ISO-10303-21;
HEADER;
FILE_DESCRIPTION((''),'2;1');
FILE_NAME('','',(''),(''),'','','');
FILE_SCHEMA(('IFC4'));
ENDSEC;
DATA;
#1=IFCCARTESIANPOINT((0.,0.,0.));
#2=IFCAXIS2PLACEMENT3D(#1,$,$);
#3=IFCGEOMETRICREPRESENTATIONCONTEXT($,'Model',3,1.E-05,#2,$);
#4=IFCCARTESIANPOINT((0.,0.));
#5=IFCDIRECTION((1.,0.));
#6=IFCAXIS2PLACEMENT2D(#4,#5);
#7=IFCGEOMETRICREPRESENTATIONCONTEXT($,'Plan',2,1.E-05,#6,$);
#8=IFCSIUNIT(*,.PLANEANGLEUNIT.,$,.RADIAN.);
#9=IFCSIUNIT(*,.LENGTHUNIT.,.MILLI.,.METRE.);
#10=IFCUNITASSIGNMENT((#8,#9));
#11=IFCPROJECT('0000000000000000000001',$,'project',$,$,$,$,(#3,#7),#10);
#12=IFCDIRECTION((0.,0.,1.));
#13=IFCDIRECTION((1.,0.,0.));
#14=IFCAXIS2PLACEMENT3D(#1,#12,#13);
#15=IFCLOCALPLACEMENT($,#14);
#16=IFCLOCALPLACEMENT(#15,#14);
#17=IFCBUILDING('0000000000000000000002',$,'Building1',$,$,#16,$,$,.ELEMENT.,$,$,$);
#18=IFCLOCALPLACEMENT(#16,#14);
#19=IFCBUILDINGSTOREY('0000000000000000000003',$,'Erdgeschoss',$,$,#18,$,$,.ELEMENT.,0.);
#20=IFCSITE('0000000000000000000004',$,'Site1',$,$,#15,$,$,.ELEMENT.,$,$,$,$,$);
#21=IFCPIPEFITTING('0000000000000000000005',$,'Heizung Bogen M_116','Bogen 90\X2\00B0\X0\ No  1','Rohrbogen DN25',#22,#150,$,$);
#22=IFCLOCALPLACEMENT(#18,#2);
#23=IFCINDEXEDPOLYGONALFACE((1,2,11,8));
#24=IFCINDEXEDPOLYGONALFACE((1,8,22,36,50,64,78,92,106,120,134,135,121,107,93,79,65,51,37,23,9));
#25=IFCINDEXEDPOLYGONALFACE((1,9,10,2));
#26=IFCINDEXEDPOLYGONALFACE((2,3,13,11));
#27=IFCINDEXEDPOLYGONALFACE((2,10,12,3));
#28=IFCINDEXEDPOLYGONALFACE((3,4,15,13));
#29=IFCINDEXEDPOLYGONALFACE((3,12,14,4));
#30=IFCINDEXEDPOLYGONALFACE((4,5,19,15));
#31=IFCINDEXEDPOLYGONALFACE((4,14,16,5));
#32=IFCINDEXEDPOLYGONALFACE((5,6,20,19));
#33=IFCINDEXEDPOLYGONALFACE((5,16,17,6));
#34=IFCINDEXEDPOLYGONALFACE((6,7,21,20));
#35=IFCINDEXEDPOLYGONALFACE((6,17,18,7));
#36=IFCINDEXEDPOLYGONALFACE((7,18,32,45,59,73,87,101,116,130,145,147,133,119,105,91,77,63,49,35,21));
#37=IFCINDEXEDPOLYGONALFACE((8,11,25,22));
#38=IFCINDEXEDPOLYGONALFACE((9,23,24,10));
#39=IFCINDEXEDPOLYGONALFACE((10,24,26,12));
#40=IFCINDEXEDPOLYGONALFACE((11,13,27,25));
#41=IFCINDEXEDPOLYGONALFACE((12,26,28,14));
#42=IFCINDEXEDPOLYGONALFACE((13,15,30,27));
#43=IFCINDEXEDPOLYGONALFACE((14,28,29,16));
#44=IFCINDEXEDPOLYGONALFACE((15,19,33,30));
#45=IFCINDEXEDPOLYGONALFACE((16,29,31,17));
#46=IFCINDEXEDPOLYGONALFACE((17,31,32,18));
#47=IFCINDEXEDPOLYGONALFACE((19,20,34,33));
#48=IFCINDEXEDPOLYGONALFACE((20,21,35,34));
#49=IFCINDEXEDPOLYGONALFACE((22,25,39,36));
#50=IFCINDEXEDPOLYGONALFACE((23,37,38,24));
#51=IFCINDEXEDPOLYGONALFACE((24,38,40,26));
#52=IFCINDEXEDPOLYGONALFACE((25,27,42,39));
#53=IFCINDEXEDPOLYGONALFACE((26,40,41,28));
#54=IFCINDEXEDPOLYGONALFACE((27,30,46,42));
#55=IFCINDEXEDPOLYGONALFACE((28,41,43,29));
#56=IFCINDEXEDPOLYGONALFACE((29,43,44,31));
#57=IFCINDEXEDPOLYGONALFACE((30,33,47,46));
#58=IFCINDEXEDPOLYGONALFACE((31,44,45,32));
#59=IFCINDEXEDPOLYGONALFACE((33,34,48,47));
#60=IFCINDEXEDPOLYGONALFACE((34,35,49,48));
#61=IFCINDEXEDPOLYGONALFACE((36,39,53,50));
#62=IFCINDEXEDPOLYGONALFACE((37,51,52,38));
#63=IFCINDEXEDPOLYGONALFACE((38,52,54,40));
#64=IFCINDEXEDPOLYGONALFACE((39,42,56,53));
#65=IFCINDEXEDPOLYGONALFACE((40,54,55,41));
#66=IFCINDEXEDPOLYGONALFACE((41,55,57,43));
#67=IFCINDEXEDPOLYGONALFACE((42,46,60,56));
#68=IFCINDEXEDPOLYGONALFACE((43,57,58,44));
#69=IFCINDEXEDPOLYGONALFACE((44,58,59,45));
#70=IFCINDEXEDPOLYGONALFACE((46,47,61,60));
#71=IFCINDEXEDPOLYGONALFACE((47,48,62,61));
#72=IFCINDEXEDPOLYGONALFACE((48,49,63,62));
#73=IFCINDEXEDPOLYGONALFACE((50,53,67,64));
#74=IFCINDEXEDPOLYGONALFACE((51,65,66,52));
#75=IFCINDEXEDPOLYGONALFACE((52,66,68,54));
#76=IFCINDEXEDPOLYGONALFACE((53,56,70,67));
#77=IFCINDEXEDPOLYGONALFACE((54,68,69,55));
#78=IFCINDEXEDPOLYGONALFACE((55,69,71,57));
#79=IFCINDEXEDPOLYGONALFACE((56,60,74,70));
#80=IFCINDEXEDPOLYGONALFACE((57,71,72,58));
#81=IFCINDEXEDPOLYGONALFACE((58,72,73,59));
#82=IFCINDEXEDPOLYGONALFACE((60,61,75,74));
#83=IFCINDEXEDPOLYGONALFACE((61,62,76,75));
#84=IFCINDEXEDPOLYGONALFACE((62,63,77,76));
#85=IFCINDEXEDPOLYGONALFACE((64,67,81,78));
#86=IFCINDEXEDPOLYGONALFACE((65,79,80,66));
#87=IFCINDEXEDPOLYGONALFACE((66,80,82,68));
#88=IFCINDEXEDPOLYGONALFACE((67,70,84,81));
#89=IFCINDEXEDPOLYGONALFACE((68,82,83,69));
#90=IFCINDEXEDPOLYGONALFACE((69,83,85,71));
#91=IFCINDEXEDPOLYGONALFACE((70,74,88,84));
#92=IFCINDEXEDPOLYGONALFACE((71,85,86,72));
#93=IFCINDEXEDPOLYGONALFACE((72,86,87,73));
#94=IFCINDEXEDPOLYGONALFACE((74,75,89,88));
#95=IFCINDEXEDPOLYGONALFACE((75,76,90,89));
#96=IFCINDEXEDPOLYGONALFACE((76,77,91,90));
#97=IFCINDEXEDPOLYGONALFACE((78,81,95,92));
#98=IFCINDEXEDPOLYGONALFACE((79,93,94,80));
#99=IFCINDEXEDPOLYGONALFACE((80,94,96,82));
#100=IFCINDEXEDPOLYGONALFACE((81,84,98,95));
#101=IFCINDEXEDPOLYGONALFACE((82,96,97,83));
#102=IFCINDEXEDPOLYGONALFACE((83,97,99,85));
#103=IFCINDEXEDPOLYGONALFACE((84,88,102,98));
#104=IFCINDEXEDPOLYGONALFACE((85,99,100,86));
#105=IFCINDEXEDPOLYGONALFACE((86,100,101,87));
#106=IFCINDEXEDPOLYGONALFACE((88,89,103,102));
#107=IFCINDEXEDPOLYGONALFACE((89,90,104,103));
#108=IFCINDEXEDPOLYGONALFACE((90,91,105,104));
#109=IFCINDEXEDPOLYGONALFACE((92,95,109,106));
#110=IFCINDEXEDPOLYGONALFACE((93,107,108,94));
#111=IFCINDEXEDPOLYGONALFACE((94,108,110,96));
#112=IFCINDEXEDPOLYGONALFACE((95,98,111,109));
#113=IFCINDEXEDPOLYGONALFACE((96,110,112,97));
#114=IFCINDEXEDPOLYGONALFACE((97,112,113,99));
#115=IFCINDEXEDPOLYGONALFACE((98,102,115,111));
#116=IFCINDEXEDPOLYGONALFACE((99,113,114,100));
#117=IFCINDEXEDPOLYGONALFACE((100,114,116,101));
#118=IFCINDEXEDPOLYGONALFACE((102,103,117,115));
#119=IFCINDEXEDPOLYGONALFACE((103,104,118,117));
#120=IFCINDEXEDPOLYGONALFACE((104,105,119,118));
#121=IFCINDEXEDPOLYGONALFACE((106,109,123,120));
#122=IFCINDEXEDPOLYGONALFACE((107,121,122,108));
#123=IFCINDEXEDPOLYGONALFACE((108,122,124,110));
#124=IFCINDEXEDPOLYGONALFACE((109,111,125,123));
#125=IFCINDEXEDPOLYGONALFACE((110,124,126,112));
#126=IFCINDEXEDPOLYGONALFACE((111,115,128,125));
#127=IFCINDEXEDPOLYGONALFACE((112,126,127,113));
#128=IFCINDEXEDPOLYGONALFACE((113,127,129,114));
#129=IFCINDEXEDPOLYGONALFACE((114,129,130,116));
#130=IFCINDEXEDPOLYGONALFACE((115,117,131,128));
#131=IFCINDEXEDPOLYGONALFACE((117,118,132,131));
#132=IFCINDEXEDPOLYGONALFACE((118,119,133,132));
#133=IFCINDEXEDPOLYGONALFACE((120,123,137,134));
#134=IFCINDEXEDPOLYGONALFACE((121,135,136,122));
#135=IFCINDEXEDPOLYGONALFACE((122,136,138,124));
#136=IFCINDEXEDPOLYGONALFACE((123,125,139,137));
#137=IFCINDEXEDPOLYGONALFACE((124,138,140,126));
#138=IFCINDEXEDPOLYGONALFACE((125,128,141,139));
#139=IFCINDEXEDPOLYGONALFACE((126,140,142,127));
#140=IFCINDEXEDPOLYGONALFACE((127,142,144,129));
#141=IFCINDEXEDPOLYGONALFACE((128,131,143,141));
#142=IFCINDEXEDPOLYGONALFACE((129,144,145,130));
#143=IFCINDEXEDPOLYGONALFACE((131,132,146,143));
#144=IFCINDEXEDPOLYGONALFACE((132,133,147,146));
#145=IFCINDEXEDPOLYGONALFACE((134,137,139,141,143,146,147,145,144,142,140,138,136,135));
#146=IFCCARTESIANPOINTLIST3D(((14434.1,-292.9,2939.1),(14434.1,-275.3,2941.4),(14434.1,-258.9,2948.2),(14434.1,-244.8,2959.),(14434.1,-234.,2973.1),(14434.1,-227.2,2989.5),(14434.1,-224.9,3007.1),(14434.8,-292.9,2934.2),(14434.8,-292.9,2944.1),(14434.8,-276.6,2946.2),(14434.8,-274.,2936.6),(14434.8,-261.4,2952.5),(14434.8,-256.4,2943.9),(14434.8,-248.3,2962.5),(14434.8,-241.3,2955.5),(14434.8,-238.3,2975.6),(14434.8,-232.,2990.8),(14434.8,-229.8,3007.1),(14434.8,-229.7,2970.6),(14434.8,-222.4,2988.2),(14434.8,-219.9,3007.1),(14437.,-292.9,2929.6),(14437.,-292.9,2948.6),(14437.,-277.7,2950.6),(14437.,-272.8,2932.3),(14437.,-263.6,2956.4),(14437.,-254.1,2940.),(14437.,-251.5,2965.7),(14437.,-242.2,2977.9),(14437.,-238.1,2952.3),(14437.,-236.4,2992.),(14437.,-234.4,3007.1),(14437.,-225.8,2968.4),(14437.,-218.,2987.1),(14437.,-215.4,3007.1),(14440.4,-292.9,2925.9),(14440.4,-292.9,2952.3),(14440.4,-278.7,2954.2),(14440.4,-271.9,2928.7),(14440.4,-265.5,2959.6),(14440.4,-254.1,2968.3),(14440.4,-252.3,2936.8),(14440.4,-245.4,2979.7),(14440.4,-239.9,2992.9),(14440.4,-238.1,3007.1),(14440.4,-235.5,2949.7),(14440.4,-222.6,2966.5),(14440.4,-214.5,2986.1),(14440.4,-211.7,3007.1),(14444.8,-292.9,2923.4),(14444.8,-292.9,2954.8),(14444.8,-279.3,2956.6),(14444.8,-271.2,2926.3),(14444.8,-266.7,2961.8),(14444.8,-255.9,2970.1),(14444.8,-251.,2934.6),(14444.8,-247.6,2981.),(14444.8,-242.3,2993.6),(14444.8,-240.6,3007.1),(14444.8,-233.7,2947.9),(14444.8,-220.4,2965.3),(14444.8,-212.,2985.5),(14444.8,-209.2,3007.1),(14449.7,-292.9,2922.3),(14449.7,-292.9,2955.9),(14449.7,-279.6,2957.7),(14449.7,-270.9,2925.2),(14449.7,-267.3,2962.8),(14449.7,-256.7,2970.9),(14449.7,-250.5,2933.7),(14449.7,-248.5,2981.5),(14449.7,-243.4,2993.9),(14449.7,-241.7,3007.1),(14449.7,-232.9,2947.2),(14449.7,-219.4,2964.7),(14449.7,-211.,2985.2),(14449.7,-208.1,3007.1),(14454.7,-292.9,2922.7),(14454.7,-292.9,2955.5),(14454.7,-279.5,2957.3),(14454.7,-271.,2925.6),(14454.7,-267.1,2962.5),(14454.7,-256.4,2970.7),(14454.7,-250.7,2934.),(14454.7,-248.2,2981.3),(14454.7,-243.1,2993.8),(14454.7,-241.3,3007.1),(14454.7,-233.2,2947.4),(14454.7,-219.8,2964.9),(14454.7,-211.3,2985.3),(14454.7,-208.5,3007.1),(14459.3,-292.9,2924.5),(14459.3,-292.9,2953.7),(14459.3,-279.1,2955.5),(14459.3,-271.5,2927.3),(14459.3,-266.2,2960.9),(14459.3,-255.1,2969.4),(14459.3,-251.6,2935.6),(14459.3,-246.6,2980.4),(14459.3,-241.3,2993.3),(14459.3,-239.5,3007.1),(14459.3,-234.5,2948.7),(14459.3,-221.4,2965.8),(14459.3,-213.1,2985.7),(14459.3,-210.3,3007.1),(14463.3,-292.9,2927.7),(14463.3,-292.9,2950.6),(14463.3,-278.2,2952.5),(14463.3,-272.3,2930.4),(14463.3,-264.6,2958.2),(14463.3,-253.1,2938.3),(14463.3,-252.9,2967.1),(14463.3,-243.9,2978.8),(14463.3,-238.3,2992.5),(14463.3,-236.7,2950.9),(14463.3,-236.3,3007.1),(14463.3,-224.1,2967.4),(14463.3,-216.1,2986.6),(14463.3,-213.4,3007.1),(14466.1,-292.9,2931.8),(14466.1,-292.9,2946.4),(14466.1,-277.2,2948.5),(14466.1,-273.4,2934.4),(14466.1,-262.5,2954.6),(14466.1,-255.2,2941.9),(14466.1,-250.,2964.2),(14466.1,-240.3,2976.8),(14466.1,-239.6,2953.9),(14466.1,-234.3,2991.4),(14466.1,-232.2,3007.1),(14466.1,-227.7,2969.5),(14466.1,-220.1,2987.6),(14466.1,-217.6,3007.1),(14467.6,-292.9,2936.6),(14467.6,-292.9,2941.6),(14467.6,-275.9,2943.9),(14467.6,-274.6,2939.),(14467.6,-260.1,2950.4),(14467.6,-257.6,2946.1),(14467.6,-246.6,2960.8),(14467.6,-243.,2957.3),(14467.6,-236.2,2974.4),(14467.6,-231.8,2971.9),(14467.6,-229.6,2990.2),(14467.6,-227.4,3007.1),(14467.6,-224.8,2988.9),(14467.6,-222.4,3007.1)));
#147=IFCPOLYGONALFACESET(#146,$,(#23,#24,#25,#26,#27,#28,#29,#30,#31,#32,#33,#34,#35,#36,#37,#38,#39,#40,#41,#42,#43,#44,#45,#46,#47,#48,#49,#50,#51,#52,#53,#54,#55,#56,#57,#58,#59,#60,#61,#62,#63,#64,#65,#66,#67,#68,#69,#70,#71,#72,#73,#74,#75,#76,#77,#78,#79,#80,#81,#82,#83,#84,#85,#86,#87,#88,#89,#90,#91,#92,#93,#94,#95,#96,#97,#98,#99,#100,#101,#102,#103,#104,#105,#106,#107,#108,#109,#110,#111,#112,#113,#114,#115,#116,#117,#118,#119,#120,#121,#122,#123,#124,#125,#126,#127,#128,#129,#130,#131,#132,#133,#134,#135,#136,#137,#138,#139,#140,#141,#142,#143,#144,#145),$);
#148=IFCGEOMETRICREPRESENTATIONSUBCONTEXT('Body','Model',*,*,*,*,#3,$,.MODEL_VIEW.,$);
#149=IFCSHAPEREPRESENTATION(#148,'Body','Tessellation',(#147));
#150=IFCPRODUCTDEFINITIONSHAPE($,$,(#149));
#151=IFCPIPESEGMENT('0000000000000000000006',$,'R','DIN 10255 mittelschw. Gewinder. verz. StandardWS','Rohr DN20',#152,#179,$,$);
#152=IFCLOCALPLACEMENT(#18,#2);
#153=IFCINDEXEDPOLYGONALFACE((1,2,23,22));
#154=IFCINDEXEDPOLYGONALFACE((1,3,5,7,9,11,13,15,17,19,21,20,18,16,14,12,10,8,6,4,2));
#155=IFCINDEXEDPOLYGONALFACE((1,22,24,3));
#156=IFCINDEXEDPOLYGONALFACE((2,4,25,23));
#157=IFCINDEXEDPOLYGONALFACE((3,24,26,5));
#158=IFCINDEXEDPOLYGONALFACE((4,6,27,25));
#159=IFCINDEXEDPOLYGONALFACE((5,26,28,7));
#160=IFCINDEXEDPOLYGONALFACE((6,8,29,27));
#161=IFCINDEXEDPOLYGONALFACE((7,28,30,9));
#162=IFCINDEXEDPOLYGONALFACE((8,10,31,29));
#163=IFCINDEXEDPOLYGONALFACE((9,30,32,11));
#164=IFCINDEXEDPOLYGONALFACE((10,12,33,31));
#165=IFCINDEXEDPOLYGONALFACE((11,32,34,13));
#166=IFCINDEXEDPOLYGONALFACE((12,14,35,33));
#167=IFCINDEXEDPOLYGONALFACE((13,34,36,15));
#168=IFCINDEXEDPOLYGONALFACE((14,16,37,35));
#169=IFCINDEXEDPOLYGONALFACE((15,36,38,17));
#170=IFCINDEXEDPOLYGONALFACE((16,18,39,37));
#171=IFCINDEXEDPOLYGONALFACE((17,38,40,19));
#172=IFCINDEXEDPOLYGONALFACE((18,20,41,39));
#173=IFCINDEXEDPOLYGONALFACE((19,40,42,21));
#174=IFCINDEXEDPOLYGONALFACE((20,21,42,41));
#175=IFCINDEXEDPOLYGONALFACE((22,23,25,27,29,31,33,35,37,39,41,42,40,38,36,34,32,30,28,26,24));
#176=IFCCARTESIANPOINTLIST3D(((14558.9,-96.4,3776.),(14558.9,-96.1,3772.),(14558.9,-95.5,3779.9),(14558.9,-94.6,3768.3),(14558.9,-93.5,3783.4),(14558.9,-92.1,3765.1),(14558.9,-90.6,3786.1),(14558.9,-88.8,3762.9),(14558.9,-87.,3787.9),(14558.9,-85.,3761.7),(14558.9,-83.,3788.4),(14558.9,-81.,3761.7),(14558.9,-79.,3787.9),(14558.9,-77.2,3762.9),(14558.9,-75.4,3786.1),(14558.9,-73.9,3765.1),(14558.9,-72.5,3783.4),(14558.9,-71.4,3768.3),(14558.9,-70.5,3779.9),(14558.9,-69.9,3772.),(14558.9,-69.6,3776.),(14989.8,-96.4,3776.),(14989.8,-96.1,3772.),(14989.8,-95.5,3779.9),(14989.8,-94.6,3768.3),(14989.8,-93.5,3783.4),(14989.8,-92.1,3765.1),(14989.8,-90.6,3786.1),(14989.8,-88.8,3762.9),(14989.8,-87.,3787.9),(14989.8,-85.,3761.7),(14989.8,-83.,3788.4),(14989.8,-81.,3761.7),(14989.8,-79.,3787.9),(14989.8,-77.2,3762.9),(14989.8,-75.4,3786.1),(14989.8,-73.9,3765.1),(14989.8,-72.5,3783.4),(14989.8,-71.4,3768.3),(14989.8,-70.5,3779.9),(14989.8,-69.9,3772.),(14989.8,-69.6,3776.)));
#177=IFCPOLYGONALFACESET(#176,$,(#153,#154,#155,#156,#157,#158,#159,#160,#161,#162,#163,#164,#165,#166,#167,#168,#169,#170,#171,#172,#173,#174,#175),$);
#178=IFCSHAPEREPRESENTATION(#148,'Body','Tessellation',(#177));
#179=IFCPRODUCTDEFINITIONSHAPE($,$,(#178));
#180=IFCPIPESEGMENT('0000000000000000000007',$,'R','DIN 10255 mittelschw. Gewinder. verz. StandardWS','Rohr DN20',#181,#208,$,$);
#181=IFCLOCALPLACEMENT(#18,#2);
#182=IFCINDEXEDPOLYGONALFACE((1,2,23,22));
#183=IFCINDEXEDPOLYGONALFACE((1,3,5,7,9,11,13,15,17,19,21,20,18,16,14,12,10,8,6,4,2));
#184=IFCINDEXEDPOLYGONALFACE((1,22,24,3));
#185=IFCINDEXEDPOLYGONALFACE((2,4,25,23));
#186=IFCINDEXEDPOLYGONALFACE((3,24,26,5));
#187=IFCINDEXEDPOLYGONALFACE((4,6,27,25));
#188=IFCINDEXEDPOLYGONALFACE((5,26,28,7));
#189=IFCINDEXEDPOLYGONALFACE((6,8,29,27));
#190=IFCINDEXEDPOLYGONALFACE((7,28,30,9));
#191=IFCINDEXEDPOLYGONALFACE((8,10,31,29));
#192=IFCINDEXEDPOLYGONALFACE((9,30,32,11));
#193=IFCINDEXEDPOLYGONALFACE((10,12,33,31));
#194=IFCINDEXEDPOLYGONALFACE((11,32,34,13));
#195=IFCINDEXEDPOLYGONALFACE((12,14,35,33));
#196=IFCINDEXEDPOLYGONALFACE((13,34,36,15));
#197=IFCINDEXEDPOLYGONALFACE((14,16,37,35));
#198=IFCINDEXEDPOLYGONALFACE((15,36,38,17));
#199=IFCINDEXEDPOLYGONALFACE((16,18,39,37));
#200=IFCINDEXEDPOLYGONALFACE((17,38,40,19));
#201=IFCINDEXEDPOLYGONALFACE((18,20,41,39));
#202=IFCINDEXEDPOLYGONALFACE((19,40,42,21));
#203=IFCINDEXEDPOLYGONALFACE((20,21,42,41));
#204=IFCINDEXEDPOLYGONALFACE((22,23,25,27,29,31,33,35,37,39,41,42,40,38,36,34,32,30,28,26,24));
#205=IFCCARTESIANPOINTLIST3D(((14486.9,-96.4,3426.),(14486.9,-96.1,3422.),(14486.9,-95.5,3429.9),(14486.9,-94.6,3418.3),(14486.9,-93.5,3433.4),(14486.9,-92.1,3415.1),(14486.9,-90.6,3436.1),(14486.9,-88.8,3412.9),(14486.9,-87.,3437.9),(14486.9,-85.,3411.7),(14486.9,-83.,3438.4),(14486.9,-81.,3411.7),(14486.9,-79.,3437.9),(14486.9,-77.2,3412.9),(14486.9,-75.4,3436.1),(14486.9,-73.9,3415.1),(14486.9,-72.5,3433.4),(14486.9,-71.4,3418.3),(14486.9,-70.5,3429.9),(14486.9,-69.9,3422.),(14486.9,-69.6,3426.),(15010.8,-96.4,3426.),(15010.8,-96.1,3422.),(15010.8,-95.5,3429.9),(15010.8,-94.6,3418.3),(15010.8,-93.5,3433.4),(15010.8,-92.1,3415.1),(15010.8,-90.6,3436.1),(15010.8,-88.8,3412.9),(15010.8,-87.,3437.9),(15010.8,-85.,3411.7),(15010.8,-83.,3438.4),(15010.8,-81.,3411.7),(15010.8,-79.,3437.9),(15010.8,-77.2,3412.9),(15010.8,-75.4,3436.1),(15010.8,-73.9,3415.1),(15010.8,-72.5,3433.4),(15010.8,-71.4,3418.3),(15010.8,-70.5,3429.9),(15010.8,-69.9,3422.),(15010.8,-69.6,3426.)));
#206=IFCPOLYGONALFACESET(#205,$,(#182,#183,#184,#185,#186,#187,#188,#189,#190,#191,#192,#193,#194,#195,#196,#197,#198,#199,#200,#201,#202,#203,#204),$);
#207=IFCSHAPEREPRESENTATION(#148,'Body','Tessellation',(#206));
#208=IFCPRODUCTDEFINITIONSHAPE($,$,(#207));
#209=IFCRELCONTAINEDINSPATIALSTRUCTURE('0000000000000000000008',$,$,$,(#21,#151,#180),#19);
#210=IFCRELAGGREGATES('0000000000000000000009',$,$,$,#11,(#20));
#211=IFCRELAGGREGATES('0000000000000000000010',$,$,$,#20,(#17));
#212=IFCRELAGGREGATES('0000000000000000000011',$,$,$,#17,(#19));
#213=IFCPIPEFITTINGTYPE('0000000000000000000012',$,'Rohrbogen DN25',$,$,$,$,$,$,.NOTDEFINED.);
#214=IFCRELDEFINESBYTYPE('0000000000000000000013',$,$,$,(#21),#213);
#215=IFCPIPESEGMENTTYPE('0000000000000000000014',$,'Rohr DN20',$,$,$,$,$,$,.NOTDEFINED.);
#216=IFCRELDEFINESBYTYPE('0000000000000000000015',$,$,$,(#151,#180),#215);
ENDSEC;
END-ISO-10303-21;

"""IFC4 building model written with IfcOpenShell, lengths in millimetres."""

from ifc_helpers import new_model, entity, si_unit, frame, origin, origin_with_axes, origin_2d_with_axis, place, context, subcontext, project, spatial, circle, extrude, source, transform, mapped, type_object, element, save


model = new_model("IFC4")

# Units and contexts
model_context = context("Model", 3, precision=1e-05, world=origin())
plan_context = context("Plan", 2, precision=1e-05, world=origin_2d_with_axis())
body_context = subcontext(model_context, "Body", "Model", "MODEL_VIEW")
ifc_project = project(units=[si_unit("PLANEANGLEUNIT", "RADIAN"), si_unit("LENGTHUNIT", "METRE", prefix="MILLI")], contexts=[model_context, plan_context])

# Site, building, storey
site_placement = place(None, origin_with_axes())
site = spatial("IfcSite", under=ifc_project, at=site_placement, Name="Site1", CompositionType="ELEMENT")
building_placement = place(site_placement, origin_with_axes())
building = spatial("IfcBuilding", under=site, at=building_placement, Name="Building1", CompositionType="ELEMENT")
storey_placement = place(building_placement, origin_with_axes())
storey = spatial("IfcBuildingStorey", under=building, at=storey_placement, Name="Erdgeschoss", CompositionType="ELEMENT", Elevation=0.0)

# Pipe fitting
pipe_fitting_type = type_object("IfcPipeFittingType", Name="Rohrbogen DN25", PredefinedType="NOTDEFINED")
shared_shape_1 = source(origin_with_axes(), body_context, "Body", "SolidModel", [
    entity("IfcRevolvedAreaSolid", entity("IfcCircleProfileDef", "AREA", None, entity("IfcAxis2Placement2D", entity("IfcCartesianPoint", [0.0, 0.0]), entity("IfcDirection", [1.0, 0.0])), 16.9), entity("IfcAxis2Placement3D", entity("IfcCartesianPoint", [-42.4, 0.0, -25.6]), entity("IfcDirection", [1.0, 0.0, 0.0]), entity("IfcDirection", [0.0, 1.0, 0.0])), entity("IfcAxis1Placement", entity("IfcCartesianPoint", [0.0, 68.0, 0.0]), entity("IfcDirection", [-1.0, 0.0, 0.0])), 1.570796),
])
pipe_fitting_1_placement = place(storey_placement, frame((14450.9, -250.5, 2964.7), z_axis=(0.0, 0.0, 1.0), x_axis=(1.0, 0.0, 0.0)))
element("IfcPipeFitting", 1, at=pipe_fitting_1_placement, inside=storey, type_object=pipe_fitting_type, Name="Heizung Bogen M_116", Description="Bogen 90° No  1", ObjectType="Rohrbogen DN25", context=body_context, shape_type="MappedRepresentation", body=[
    mapped(shared_shape_1, transform((0.0, 0.0, 0.0), x_axis=(0.0, 1.0, 0.0), y_axis=(-1.0, 0.0, 0.0), z_axis=(0.0, 0.0, 1.0), scale=1.0)),
])

# Pipe segments
pipe_segment_type_1 = type_object("IfcPipeSegmentType", Name="Rohr DN20", PredefinedType="NOTDEFINED")
pipe_segment_1_placement = place(storey_placement, frame((14774.4, -83.2, 3775.0), z_axis=(0.0, 0.0, 1.0), x_axis=(1.0, 0.0, 0.0)))
element("IfcPipeSegment", 2, at=pipe_segment_1_placement, inside=storey, type_object=pipe_segment_type_1, Name="R", Description="DIN 10255 mittelschw. Gewinder. verz. StandardWS", ObjectType="Rohr DN20", context=body_context, shape_type="SolidModel", body=[
    extrude(circle(Radius=13.4, at=origin_2d_with_axis()), frame((215.5, 0.2, 0.0), z_axis=(-1.0, 0.0, 0.0), x_axis=(0.0, 0.0, 1.0)), (0.0, 0.0, 1.0), 430.9),
])
pipe_segment_2_placement = place(storey_placement, frame((14748.9, -83.2, 3425.0), z_axis=(0.0, 0.0, 1.0), x_axis=(1.0, 0.0, 0.0)))
element("IfcPipeSegment", 3, at=pipe_segment_2_placement, inside=storey, type_object=pipe_segment_type_1, Name="R", Description="DIN 10255 mittelschw. Gewinder. verz. StandardWS", ObjectType="Rohr DN20", context=body_context, shape_type="SolidModel", body=[
    extrude(circle(Radius=13.4, at=origin_2d_with_axis()), frame((262.0, 0.2, 0.0), z_axis=(-1.0, 0.0, 0.0), x_axis=(0.0, 0.0, 1.0)), (0.0, 0.0, 1.0), 523.9),
])

save(model, "model.ifc")
